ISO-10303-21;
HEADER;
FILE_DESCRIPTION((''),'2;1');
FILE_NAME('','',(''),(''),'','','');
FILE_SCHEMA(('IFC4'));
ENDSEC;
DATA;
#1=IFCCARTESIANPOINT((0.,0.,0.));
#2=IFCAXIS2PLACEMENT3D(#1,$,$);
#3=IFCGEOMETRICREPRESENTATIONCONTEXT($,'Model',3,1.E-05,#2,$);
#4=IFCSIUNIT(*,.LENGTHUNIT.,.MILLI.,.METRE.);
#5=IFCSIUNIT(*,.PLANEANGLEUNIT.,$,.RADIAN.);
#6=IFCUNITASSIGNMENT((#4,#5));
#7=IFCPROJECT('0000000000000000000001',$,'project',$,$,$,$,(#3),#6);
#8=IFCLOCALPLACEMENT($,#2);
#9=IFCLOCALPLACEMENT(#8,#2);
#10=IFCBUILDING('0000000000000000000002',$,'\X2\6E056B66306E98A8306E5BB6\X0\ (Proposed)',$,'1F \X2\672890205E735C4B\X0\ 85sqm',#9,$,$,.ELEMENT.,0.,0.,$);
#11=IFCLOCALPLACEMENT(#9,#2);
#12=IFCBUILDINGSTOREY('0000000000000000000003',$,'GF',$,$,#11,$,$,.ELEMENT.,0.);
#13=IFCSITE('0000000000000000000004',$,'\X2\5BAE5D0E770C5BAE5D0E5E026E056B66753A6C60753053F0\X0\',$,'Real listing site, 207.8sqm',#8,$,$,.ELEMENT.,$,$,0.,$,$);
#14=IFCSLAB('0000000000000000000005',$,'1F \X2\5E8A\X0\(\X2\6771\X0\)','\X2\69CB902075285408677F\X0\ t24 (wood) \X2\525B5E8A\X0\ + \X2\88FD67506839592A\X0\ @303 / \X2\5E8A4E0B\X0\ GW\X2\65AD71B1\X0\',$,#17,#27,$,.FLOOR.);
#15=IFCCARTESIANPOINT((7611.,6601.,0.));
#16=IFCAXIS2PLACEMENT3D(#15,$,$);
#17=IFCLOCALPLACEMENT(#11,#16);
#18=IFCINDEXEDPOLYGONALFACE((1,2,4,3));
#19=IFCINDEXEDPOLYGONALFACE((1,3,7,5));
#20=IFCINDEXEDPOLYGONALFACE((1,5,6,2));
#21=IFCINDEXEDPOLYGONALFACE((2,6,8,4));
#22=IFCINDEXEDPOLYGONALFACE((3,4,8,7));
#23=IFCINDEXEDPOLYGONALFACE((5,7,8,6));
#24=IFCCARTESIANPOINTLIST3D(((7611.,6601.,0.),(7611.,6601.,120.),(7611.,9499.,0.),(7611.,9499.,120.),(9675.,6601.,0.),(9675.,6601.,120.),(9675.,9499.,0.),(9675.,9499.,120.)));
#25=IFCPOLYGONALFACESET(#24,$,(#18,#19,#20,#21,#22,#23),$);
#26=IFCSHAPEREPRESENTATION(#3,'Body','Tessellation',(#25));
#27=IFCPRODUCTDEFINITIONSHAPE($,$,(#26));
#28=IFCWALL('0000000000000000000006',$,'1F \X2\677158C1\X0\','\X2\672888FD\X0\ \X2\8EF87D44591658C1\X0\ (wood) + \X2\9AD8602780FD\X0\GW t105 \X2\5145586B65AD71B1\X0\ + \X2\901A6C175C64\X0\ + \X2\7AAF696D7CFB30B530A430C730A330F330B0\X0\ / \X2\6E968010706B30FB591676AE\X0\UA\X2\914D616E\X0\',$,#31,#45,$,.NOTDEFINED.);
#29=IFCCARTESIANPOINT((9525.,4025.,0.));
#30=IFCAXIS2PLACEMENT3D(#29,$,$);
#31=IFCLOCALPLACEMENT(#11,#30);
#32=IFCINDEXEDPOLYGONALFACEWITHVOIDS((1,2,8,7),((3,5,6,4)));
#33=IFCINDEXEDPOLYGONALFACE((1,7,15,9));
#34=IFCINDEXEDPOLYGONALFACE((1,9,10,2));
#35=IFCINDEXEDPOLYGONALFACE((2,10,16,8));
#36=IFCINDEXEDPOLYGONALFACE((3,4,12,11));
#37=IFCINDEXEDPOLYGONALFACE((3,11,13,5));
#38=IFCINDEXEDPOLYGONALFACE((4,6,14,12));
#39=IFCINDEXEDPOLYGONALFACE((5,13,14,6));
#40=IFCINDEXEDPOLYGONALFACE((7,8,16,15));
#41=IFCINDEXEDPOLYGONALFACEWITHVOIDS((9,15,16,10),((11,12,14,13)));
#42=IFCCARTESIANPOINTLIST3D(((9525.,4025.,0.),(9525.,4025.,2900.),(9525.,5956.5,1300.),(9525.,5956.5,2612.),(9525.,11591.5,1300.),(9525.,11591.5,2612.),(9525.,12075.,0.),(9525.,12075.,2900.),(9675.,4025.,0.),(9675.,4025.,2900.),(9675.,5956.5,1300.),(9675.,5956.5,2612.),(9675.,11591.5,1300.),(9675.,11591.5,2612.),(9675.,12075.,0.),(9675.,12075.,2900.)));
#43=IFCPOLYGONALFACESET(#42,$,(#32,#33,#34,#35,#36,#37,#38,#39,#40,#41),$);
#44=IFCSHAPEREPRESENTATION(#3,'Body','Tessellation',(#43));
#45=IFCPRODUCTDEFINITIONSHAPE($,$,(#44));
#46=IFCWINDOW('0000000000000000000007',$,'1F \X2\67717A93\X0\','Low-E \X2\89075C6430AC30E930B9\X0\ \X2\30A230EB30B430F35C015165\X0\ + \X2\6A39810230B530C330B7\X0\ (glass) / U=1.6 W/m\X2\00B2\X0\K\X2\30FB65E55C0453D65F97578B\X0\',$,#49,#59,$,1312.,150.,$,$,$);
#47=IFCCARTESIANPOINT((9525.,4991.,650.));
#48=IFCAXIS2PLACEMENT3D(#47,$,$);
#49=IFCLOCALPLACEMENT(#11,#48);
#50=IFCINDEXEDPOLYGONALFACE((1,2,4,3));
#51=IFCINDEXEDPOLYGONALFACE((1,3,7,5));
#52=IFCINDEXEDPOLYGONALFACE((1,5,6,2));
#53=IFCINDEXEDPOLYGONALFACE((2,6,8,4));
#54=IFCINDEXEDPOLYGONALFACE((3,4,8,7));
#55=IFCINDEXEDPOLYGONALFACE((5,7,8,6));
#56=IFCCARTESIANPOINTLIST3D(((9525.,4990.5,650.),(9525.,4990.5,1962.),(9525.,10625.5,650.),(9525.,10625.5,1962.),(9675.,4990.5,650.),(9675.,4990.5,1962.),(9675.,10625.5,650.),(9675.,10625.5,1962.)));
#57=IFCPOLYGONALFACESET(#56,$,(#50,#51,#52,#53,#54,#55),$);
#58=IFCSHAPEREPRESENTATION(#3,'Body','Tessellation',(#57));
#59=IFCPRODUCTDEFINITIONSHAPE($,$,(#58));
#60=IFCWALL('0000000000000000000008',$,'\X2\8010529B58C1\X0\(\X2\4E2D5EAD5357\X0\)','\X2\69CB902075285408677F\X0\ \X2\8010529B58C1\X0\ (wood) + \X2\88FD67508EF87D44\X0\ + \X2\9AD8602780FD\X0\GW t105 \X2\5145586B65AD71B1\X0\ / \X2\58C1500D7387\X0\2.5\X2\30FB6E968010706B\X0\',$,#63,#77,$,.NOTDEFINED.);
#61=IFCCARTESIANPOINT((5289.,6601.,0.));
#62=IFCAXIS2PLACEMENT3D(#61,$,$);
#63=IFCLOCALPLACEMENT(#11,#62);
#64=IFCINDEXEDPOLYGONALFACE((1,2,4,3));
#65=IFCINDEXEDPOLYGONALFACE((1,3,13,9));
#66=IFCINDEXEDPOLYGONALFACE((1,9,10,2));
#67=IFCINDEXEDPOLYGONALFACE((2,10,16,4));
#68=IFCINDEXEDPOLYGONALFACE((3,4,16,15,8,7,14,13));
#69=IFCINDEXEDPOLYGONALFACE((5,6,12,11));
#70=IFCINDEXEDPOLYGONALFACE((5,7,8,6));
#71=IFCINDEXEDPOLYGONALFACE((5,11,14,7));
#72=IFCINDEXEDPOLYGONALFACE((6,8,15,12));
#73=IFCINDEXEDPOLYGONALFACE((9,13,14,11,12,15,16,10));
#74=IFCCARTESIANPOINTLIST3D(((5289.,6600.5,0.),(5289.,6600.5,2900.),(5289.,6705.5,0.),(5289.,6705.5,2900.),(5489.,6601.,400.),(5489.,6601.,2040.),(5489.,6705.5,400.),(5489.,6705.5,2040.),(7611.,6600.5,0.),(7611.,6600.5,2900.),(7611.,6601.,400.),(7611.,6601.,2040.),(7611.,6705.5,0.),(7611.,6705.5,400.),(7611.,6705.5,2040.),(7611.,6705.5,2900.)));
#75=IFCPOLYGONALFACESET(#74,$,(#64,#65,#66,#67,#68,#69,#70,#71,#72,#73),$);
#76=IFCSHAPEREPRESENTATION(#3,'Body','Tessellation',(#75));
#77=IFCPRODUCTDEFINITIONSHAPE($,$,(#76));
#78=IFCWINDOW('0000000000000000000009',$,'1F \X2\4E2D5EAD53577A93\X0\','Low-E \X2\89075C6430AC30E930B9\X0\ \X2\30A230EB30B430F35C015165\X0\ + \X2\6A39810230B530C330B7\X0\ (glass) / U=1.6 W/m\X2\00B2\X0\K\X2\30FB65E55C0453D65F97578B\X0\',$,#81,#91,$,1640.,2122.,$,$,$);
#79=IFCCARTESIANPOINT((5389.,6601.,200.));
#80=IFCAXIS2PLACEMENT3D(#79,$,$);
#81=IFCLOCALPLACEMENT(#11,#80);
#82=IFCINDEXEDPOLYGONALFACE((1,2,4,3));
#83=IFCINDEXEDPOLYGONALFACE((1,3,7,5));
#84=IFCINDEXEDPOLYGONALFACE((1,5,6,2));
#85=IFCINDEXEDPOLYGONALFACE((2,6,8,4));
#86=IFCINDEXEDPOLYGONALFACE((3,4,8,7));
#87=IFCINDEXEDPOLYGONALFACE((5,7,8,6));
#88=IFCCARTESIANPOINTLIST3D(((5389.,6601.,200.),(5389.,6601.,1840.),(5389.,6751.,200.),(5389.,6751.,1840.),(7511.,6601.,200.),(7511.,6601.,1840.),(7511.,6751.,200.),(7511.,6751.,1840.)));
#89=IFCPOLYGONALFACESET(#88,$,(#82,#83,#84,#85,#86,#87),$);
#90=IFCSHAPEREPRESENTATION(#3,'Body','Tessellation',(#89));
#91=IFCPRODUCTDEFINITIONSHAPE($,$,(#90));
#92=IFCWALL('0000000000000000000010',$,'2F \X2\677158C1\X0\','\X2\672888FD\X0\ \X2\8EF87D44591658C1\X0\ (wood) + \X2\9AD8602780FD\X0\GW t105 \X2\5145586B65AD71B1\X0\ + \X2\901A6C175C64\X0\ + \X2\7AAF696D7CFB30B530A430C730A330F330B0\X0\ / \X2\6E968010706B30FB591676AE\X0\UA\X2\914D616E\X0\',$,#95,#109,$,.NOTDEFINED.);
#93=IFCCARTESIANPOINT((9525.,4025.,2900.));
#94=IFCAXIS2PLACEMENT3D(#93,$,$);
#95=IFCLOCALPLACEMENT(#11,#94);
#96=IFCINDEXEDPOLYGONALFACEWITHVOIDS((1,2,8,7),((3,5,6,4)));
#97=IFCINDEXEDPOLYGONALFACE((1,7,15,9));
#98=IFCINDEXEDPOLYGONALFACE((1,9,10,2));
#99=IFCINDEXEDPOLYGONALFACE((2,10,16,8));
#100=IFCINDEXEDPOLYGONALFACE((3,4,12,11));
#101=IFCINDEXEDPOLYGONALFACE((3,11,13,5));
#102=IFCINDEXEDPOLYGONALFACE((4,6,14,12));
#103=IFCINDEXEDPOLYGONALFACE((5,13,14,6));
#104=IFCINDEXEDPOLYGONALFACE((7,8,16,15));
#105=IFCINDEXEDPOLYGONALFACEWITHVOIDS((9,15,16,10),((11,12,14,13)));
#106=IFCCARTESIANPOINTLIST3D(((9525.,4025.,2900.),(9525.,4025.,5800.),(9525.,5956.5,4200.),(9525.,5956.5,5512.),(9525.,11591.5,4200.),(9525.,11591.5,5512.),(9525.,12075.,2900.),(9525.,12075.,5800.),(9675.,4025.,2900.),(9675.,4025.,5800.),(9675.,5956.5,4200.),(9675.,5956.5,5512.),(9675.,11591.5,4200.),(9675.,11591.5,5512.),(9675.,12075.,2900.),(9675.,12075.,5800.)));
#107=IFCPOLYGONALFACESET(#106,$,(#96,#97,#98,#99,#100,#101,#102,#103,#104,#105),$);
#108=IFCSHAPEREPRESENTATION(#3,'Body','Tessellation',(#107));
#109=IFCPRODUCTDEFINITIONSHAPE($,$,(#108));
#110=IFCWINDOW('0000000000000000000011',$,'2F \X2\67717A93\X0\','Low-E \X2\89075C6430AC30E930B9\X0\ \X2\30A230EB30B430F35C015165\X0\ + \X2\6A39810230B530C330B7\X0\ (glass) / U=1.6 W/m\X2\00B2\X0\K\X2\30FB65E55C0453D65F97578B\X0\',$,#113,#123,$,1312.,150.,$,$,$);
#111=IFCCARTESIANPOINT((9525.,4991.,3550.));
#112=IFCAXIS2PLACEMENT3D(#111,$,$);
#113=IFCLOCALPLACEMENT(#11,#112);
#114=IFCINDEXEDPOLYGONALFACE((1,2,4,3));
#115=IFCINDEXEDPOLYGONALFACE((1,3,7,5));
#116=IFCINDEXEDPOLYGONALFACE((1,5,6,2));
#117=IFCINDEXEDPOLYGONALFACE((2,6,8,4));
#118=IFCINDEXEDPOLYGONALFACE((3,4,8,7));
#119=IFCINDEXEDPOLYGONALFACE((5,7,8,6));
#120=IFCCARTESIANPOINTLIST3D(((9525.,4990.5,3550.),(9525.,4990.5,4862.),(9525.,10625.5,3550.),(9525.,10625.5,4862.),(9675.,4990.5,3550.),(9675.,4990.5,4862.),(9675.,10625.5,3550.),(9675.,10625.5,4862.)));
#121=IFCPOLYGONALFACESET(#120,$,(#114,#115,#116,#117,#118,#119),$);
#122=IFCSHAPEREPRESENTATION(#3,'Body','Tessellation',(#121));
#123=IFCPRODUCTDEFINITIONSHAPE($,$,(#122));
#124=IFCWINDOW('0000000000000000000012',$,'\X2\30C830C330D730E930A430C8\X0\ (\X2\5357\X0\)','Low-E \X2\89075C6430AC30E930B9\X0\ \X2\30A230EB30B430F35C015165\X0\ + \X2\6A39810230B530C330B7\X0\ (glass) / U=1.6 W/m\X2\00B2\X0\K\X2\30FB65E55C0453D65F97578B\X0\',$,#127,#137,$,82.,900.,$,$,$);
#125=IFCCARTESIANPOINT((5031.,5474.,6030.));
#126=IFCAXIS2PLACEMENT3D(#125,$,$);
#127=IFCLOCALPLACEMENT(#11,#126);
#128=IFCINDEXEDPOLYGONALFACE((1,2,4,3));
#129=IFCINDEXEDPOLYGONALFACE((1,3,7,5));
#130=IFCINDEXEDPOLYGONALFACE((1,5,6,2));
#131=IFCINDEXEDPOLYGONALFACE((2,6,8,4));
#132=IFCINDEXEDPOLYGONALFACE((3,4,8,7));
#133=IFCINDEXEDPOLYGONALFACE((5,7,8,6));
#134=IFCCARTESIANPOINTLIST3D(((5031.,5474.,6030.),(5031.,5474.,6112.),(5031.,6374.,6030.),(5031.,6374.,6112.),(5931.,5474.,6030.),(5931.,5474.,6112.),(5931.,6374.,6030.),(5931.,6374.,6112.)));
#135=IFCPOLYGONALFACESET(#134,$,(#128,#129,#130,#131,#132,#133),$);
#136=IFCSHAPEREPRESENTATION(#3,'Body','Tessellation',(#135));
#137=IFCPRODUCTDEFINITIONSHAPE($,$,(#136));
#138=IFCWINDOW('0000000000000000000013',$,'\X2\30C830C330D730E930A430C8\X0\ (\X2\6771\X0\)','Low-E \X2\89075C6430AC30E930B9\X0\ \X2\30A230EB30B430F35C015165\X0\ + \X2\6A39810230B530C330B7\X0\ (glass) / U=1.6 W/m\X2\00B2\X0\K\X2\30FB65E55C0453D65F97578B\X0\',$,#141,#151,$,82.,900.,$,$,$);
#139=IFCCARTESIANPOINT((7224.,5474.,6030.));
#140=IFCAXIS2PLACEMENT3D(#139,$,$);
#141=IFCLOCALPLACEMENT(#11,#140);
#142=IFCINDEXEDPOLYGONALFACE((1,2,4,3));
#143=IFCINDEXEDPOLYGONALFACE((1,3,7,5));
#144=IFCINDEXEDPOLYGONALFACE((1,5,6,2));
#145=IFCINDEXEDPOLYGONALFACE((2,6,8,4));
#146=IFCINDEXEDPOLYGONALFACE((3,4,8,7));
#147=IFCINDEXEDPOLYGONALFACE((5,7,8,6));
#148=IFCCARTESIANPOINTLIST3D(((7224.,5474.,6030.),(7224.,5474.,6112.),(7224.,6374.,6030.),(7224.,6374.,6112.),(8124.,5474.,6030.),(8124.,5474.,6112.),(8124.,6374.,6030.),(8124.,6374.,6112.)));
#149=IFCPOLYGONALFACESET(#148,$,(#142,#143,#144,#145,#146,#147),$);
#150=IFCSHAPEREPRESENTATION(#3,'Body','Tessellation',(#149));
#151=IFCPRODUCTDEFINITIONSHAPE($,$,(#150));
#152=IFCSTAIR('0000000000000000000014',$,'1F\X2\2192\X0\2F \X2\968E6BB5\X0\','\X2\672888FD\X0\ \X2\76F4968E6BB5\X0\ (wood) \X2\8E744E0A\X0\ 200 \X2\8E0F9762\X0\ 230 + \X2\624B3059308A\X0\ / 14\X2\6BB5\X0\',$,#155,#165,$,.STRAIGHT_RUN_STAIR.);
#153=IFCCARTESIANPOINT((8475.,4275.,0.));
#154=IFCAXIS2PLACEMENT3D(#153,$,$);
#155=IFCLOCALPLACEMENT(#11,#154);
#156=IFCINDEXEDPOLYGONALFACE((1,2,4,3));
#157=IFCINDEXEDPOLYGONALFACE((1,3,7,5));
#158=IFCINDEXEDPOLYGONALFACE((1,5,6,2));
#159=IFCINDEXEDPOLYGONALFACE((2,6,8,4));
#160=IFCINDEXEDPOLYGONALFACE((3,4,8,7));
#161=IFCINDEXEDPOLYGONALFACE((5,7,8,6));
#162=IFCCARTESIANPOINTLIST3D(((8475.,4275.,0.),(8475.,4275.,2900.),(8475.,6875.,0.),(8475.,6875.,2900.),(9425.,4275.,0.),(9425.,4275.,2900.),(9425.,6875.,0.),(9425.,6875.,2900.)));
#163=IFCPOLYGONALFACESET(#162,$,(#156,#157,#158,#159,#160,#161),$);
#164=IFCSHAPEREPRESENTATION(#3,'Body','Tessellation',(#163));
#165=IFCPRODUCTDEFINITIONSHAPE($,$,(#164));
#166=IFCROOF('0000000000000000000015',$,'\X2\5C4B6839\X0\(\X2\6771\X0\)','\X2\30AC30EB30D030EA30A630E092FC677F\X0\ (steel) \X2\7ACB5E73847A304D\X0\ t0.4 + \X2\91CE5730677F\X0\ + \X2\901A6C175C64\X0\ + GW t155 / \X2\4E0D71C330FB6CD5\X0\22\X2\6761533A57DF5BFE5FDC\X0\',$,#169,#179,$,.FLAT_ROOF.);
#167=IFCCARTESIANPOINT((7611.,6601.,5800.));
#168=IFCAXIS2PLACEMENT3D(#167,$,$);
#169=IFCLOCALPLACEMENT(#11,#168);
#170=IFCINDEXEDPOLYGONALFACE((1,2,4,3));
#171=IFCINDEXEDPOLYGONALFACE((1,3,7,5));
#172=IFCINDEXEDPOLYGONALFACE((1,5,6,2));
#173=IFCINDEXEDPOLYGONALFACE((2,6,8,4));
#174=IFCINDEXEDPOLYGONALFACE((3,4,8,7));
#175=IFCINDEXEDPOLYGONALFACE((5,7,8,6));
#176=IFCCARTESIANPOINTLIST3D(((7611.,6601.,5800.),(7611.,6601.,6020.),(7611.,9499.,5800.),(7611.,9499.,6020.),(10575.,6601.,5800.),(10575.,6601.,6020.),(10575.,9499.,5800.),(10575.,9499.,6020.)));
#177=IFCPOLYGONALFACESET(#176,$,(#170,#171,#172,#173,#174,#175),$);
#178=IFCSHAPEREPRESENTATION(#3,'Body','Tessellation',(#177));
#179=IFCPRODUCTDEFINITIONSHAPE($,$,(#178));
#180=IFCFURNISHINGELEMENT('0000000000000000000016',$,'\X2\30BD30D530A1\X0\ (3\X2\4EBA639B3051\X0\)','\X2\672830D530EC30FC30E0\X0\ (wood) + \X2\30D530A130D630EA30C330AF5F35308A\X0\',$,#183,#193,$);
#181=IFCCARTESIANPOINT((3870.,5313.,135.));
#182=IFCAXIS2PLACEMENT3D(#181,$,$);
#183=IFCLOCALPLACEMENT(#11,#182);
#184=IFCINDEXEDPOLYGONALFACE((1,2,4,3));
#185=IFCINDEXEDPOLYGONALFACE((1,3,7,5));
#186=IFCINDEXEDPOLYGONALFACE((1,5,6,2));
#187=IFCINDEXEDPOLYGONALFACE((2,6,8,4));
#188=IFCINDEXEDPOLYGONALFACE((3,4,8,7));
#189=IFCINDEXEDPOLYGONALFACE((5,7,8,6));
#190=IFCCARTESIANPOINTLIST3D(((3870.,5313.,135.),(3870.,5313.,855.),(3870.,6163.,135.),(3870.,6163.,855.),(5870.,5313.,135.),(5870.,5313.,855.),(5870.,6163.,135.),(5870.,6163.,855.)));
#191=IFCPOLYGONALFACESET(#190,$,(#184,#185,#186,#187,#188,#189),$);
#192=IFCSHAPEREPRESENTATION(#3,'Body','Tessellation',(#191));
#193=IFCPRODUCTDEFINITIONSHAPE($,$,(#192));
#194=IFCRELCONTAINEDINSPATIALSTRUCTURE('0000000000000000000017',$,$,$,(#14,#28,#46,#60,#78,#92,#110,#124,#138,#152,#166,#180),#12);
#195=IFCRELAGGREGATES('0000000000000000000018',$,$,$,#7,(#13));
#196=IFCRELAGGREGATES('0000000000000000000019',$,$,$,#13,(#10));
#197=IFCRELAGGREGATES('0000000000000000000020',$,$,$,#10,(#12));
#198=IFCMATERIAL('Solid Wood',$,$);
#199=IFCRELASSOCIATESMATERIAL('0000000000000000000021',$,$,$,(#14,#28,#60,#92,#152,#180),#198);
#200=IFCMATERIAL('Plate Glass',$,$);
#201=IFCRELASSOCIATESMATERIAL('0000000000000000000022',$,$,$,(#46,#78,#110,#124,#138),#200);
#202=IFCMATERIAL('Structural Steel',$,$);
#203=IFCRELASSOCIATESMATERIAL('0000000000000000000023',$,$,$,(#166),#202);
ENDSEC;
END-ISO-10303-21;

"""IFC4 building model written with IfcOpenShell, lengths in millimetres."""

from ifc_helpers import new_model, si_unit, frame, frame_2d, origin, place, context, project, spatial, rectangle, extrude, material, element, fill, save


model = new_model("IFC4")

# Units and contexts
model_context = context("Model", 3, precision=1e-05, world=origin())
ifc_project = project(units=[si_unit("LENGTHUNIT", "METRE", prefix="MILLI"), si_unit("PLANEANGLEUNIT", "RADIAN")], contexts=[model_context])

# Site, building, storey
site_placement = place(None, origin())
site = spatial("IfcSite", under=ifc_project, at=site_placement, Name="宮崎県宮崎市清武町池田台", ObjectType="Real listing site, 207.8sqm", CompositionType="ELEMENT", RefElevation=0.0)
building_placement = place(site_placement, origin())
building = spatial("IfcBuilding", under=site, at=building_placement, Name="清武の風の家 (Proposed)", ObjectType="1F 木造平屋 85sqm", CompositionType="ELEMENT", ElevationOfRefHeight=0.0, ElevationOfTerrain=0.0)
storey_placement = place(building_placement, origin())
storey = spatial("IfcBuildingStorey", under=building, at=storey_placement, Name="GF", CompositionType="ELEMENT", Elevation=0.0)

# Slab
ifc_material_1 = material(Name="Solid Wood")
slab_placement = place(storey_placement, frame((7611.0, 6601.0, 0.0)))
element("IfcSlab", 1, at=slab_placement, inside=storey, material=ifc_material_1, Name="1F 床(東)", Description="構造用合板 t24 (wood) 剛床 + 製材根太 @303 / 床下 GW断熱", PredefinedType="FLOOR", context=model_context, shape_type="SweptSolid", body=[
    extrude(rectangle(XDim=2064.0, YDim=2898.0, at=frame_2d((1032.0, 1449.0))), frame((7611.0, 6601.0, 0.0)), (0.0, 0.0, 1.0), 120.0),
])

# Walls, openings, windows
wall_1_placement = place(storey_placement, frame((9525.0, 4025.0, 0.0)))
wall_1 = element("IfcWall", 2, at=wall_1_placement, inside=storey, material=ifc_material_1, Name="1F 東壁", Description="木製 軸組外壁 (wood) + 高性能GW t105 充填断熱 + 通気層 + 窯業系サイディング / 準耐火・外皮UA配慮", PredefinedType="NOTDEFINED", context=model_context, shape_type="SweptSolid", body=[
    extrude(rectangle(XDim=150.0, YDim=8050.0, at=frame_2d((75.0, 4025.0))), frame((9525.0, 4025.0, 0.0)), (0.0, 0.0, 1.0), 2900.0),
])
opening_1_placement = place(storey_placement, frame((9525.0, 4991.0, 650.0)))
opening_1 = element("IfcOpeningElement", 3, at=opening_1_placement, cuts=wall_1, PredefinedType="NOTDEFINED", context=model_context, shape_type="SweptSolid", body=[
    extrude(rectangle(XDim=150.0, YDim=5635.0, at=frame_2d((75.0, 2817.0))), frame((9525.0, 4991.0, 650.0)), (0.0, 0.0, 1.0), 1312.0),
])
ifc_material_2 = material(Name="Plate Glass")
window_1_placement = place(storey_placement, frame((9525.0, 4991.0, 650.0)))
window_1 = element("IfcWindow", 4, at=window_1_placement, inside=storey, material=ifc_material_2, Name="1F 東窓", Description="Low-E 複層ガラス アルゴン封入 + 樹脂サッシ (glass) / U=1.6 W/m²K・日射取得型", OverallHeight=1312.0, OverallWidth=150.0, context=model_context, shape_type="SweptSolid", body=[
    extrude(rectangle(XDim=150.0, YDim=5635.0, at=frame_2d((75.0, 2817.0))), frame((9525.0, 4991.0, 650.0)), (0.0, 0.0, 1.0), 1312.0),
])
fill(opening_1, window_1)
wall_2_placement = place(storey_placement, frame((5289.0, 6601.0, 0.0)))
wall_2 = element("IfcWall", 5, at=wall_2_placement, inside=storey, material=ifc_material_1, Name="耐力壁(中庭南)", Description="構造用合板 耐力壁 (wood) + 製材軸組 + 高性能GW t105 充填断熱 / 壁倍率2.5・準耐火", PredefinedType="NOTDEFINED", context=model_context, shape_type="SweptSolid", body=[
    extrude(rectangle(XDim=2322.0, YDim=105.0, at=frame_2d((1161.0, 52.0))), frame((5289.0, 6601.0, 0.0)), (0.0, 0.0, 1.0), 2900.0),
])
opening_2_placement = place(storey_placement, frame((5389.0, 6601.0, 200.0)))
opening_2 = element("IfcOpeningElement", 6, at=opening_2_placement, cuts=wall_2, PredefinedType="NOTDEFINED", context=model_context, shape_type="SweptSolid", body=[
    extrude(rectangle(XDim=2122.0, YDim=150.0, at=frame_2d((1061.0, 75.0))), frame((5389.0, 6601.0, 200.0)), (0.0, 0.0, 1.0), 1640.0),
])
window_2_placement = place(storey_placement, frame((5389.0, 6601.0, 200.0)))
window_2 = element("IfcWindow", 7, at=window_2_placement, inside=storey, material=ifc_material_2, Name="1F 中庭南窓", Description="Low-E 複層ガラス アルゴン封入 + 樹脂サッシ (glass) / U=1.6 W/m²K・日射取得型", OverallHeight=1640.0, OverallWidth=2122.0, context=model_context, shape_type="SweptSolid", body=[
    extrude(rectangle(XDim=2122.0, YDim=150.0, at=frame_2d((1061.0, 75.0))), frame((5389.0, 6601.0, 200.0)), (0.0, 0.0, 1.0), 1640.0),
])
fill(opening_2, window_2)

# Wall, opening, window
wall_3_placement = place(storey_placement, frame((9525.0, 4025.0, 2900.0)))
wall_3 = element("IfcWall", 8, at=wall_3_placement, inside=storey, material=ifc_material_1, Name="2F 東壁", Description="木製 軸組外壁 (wood) + 高性能GW t105 充填断熱 + 通気層 + 窯業系サイディング / 準耐火・外皮UA配慮", PredefinedType="NOTDEFINED", context=model_context, shape_type="SweptSolid", body=[
    extrude(rectangle(XDim=150.0, YDim=8050.0, at=frame_2d((75.0, 4025.0))), frame((9525.0, 4025.0, 2900.0)), (0.0, 0.0, 1.0), 2900.0),
])
opening_3_placement = place(storey_placement, frame((9525.0, 4991.0, 3550.0)))
opening_3 = element("IfcOpeningElement", 9, at=opening_3_placement, cuts=wall_3, PredefinedType="NOTDEFINED", context=model_context, shape_type="SweptSolid", body=[
    extrude(rectangle(XDim=150.0, YDim=5635.0, at=frame_2d((75.0, 2817.0))), frame((9525.0, 4991.0, 3550.0)), (0.0, 0.0, 1.0), 1312.0),
])
window_3_placement = place(storey_placement, frame((9525.0, 4991.0, 3550.0)))
window_3 = element("IfcWindow", 10, at=window_3_placement, inside=storey, material=ifc_material_2, Name="2F 東窓", Description="Low-E 複層ガラス アルゴン封入 + 樹脂サッシ (glass) / U=1.6 W/m²K・日射取得型", OverallHeight=1312.0, OverallWidth=150.0, context=model_context, shape_type="SweptSolid", body=[
    extrude(rectangle(XDim=150.0, YDim=5635.0, at=frame_2d((75.0, 2817.0))), frame((9525.0, 4991.0, 3550.0)), (0.0, 0.0, 1.0), 1312.0),
])
fill(opening_3, window_3)

# Windows
window_4_placement = place(storey_placement, frame((5031.0, 5474.0, 6030.0)))
element("IfcWindow", 11, at=window_4_placement, inside=storey, material=ifc_material_2, Name="トップライト (南)", Description="Low-E 複層ガラス アルゴン封入 + 樹脂サッシ (glass) / U=1.6 W/m²K・日射取得型", OverallHeight=82.0, OverallWidth=900.0, context=model_context, shape_type="SweptSolid", body=[
    extrude(rectangle(XDim=900.0, YDim=900.0, at=frame_2d((450.0, 450.0))), frame((5031.0, 5474.0, 6030.0)), (0.0, 0.0, 1.0), 82.0),
])
window_5_placement = place(storey_placement, frame((7224.0, 5474.0, 6030.0)))
element("IfcWindow", 12, at=window_5_placement, inside=storey, material=ifc_material_2, Name="トップライト (東)", Description="Low-E 複層ガラス アルゴン封入 + 樹脂サッシ (glass) / U=1.6 W/m²K・日射取得型", OverallHeight=82.0, OverallWidth=900.0, context=model_context, shape_type="SweptSolid", body=[
    extrude(rectangle(XDim=900.0, YDim=900.0, at=frame_2d((450.0, 450.0))), frame((7224.0, 5474.0, 6030.0)), (0.0, 0.0, 1.0), 82.0),
])

# Stair
stair_placement = place(storey_placement, frame((8475.0, 4275.0, 0.0)))
element("IfcStair", 13, at=stair_placement, inside=storey, material=ifc_material_1, Name="1F→2F 階段", Description="木製 直階段 (wood) 蹴上 200 踏面 230 + 手すり / 14段", PredefinedType="STRAIGHT_RUN_STAIR", context=model_context, shape_type="SweptSolid", body=[
    extrude(rectangle(XDim=950.0, YDim=2600.0, at=frame_2d((475.0, 1300.0))), frame((8475.0, 4275.0, 0.0)), (0.0, 0.0, 1.0), 2900.0),
])

# Roof
ifc_material_3 = material(Name="Structural Steel")
roof_placement = place(storey_placement, frame((7611.0, 6601.0, 5800.0)))
element("IfcRoof", 14, at=roof_placement, inside=storey, material=ifc_material_3, Name="屋根(東)", Description="ガルバリウム鋼板 (steel) 立平葺き t0.4 + 野地板 + 通気層 + GW t155 / 不燃・法22条区域対応", PredefinedType="FLAT_ROOF", context=model_context, shape_type="SweptSolid", body=[
    extrude(rectangle(XDim=2964.0, YDim=2898.0, at=frame_2d((1482.0, 1449.0))), frame((7611.0, 6601.0, 5800.0)), (0.0, 0.0, 1.0), 220.0),
])

# Furnishing element
furnishing_1_placement = place(storey_placement, frame((3870.0, 5313.0, 135.0)))
element("IfcFurnishingElement", 15, at=furnishing_1_placement, inside=storey, material=ifc_material_1, Name="ソファ (3人掛け)", Description="木フレーム (wood) + ファブリック張り", context=model_context, shape_type="SweptSolid", body=[
    extrude(rectangle(XDim=2000.0, YDim=850.0, at=frame_2d((1000.0, 425.0))), frame((3870.0, 5313.0, 135.0)), (0.0, 0.0, 1.0), 720.0),
])

save(model, "model.ifc")
